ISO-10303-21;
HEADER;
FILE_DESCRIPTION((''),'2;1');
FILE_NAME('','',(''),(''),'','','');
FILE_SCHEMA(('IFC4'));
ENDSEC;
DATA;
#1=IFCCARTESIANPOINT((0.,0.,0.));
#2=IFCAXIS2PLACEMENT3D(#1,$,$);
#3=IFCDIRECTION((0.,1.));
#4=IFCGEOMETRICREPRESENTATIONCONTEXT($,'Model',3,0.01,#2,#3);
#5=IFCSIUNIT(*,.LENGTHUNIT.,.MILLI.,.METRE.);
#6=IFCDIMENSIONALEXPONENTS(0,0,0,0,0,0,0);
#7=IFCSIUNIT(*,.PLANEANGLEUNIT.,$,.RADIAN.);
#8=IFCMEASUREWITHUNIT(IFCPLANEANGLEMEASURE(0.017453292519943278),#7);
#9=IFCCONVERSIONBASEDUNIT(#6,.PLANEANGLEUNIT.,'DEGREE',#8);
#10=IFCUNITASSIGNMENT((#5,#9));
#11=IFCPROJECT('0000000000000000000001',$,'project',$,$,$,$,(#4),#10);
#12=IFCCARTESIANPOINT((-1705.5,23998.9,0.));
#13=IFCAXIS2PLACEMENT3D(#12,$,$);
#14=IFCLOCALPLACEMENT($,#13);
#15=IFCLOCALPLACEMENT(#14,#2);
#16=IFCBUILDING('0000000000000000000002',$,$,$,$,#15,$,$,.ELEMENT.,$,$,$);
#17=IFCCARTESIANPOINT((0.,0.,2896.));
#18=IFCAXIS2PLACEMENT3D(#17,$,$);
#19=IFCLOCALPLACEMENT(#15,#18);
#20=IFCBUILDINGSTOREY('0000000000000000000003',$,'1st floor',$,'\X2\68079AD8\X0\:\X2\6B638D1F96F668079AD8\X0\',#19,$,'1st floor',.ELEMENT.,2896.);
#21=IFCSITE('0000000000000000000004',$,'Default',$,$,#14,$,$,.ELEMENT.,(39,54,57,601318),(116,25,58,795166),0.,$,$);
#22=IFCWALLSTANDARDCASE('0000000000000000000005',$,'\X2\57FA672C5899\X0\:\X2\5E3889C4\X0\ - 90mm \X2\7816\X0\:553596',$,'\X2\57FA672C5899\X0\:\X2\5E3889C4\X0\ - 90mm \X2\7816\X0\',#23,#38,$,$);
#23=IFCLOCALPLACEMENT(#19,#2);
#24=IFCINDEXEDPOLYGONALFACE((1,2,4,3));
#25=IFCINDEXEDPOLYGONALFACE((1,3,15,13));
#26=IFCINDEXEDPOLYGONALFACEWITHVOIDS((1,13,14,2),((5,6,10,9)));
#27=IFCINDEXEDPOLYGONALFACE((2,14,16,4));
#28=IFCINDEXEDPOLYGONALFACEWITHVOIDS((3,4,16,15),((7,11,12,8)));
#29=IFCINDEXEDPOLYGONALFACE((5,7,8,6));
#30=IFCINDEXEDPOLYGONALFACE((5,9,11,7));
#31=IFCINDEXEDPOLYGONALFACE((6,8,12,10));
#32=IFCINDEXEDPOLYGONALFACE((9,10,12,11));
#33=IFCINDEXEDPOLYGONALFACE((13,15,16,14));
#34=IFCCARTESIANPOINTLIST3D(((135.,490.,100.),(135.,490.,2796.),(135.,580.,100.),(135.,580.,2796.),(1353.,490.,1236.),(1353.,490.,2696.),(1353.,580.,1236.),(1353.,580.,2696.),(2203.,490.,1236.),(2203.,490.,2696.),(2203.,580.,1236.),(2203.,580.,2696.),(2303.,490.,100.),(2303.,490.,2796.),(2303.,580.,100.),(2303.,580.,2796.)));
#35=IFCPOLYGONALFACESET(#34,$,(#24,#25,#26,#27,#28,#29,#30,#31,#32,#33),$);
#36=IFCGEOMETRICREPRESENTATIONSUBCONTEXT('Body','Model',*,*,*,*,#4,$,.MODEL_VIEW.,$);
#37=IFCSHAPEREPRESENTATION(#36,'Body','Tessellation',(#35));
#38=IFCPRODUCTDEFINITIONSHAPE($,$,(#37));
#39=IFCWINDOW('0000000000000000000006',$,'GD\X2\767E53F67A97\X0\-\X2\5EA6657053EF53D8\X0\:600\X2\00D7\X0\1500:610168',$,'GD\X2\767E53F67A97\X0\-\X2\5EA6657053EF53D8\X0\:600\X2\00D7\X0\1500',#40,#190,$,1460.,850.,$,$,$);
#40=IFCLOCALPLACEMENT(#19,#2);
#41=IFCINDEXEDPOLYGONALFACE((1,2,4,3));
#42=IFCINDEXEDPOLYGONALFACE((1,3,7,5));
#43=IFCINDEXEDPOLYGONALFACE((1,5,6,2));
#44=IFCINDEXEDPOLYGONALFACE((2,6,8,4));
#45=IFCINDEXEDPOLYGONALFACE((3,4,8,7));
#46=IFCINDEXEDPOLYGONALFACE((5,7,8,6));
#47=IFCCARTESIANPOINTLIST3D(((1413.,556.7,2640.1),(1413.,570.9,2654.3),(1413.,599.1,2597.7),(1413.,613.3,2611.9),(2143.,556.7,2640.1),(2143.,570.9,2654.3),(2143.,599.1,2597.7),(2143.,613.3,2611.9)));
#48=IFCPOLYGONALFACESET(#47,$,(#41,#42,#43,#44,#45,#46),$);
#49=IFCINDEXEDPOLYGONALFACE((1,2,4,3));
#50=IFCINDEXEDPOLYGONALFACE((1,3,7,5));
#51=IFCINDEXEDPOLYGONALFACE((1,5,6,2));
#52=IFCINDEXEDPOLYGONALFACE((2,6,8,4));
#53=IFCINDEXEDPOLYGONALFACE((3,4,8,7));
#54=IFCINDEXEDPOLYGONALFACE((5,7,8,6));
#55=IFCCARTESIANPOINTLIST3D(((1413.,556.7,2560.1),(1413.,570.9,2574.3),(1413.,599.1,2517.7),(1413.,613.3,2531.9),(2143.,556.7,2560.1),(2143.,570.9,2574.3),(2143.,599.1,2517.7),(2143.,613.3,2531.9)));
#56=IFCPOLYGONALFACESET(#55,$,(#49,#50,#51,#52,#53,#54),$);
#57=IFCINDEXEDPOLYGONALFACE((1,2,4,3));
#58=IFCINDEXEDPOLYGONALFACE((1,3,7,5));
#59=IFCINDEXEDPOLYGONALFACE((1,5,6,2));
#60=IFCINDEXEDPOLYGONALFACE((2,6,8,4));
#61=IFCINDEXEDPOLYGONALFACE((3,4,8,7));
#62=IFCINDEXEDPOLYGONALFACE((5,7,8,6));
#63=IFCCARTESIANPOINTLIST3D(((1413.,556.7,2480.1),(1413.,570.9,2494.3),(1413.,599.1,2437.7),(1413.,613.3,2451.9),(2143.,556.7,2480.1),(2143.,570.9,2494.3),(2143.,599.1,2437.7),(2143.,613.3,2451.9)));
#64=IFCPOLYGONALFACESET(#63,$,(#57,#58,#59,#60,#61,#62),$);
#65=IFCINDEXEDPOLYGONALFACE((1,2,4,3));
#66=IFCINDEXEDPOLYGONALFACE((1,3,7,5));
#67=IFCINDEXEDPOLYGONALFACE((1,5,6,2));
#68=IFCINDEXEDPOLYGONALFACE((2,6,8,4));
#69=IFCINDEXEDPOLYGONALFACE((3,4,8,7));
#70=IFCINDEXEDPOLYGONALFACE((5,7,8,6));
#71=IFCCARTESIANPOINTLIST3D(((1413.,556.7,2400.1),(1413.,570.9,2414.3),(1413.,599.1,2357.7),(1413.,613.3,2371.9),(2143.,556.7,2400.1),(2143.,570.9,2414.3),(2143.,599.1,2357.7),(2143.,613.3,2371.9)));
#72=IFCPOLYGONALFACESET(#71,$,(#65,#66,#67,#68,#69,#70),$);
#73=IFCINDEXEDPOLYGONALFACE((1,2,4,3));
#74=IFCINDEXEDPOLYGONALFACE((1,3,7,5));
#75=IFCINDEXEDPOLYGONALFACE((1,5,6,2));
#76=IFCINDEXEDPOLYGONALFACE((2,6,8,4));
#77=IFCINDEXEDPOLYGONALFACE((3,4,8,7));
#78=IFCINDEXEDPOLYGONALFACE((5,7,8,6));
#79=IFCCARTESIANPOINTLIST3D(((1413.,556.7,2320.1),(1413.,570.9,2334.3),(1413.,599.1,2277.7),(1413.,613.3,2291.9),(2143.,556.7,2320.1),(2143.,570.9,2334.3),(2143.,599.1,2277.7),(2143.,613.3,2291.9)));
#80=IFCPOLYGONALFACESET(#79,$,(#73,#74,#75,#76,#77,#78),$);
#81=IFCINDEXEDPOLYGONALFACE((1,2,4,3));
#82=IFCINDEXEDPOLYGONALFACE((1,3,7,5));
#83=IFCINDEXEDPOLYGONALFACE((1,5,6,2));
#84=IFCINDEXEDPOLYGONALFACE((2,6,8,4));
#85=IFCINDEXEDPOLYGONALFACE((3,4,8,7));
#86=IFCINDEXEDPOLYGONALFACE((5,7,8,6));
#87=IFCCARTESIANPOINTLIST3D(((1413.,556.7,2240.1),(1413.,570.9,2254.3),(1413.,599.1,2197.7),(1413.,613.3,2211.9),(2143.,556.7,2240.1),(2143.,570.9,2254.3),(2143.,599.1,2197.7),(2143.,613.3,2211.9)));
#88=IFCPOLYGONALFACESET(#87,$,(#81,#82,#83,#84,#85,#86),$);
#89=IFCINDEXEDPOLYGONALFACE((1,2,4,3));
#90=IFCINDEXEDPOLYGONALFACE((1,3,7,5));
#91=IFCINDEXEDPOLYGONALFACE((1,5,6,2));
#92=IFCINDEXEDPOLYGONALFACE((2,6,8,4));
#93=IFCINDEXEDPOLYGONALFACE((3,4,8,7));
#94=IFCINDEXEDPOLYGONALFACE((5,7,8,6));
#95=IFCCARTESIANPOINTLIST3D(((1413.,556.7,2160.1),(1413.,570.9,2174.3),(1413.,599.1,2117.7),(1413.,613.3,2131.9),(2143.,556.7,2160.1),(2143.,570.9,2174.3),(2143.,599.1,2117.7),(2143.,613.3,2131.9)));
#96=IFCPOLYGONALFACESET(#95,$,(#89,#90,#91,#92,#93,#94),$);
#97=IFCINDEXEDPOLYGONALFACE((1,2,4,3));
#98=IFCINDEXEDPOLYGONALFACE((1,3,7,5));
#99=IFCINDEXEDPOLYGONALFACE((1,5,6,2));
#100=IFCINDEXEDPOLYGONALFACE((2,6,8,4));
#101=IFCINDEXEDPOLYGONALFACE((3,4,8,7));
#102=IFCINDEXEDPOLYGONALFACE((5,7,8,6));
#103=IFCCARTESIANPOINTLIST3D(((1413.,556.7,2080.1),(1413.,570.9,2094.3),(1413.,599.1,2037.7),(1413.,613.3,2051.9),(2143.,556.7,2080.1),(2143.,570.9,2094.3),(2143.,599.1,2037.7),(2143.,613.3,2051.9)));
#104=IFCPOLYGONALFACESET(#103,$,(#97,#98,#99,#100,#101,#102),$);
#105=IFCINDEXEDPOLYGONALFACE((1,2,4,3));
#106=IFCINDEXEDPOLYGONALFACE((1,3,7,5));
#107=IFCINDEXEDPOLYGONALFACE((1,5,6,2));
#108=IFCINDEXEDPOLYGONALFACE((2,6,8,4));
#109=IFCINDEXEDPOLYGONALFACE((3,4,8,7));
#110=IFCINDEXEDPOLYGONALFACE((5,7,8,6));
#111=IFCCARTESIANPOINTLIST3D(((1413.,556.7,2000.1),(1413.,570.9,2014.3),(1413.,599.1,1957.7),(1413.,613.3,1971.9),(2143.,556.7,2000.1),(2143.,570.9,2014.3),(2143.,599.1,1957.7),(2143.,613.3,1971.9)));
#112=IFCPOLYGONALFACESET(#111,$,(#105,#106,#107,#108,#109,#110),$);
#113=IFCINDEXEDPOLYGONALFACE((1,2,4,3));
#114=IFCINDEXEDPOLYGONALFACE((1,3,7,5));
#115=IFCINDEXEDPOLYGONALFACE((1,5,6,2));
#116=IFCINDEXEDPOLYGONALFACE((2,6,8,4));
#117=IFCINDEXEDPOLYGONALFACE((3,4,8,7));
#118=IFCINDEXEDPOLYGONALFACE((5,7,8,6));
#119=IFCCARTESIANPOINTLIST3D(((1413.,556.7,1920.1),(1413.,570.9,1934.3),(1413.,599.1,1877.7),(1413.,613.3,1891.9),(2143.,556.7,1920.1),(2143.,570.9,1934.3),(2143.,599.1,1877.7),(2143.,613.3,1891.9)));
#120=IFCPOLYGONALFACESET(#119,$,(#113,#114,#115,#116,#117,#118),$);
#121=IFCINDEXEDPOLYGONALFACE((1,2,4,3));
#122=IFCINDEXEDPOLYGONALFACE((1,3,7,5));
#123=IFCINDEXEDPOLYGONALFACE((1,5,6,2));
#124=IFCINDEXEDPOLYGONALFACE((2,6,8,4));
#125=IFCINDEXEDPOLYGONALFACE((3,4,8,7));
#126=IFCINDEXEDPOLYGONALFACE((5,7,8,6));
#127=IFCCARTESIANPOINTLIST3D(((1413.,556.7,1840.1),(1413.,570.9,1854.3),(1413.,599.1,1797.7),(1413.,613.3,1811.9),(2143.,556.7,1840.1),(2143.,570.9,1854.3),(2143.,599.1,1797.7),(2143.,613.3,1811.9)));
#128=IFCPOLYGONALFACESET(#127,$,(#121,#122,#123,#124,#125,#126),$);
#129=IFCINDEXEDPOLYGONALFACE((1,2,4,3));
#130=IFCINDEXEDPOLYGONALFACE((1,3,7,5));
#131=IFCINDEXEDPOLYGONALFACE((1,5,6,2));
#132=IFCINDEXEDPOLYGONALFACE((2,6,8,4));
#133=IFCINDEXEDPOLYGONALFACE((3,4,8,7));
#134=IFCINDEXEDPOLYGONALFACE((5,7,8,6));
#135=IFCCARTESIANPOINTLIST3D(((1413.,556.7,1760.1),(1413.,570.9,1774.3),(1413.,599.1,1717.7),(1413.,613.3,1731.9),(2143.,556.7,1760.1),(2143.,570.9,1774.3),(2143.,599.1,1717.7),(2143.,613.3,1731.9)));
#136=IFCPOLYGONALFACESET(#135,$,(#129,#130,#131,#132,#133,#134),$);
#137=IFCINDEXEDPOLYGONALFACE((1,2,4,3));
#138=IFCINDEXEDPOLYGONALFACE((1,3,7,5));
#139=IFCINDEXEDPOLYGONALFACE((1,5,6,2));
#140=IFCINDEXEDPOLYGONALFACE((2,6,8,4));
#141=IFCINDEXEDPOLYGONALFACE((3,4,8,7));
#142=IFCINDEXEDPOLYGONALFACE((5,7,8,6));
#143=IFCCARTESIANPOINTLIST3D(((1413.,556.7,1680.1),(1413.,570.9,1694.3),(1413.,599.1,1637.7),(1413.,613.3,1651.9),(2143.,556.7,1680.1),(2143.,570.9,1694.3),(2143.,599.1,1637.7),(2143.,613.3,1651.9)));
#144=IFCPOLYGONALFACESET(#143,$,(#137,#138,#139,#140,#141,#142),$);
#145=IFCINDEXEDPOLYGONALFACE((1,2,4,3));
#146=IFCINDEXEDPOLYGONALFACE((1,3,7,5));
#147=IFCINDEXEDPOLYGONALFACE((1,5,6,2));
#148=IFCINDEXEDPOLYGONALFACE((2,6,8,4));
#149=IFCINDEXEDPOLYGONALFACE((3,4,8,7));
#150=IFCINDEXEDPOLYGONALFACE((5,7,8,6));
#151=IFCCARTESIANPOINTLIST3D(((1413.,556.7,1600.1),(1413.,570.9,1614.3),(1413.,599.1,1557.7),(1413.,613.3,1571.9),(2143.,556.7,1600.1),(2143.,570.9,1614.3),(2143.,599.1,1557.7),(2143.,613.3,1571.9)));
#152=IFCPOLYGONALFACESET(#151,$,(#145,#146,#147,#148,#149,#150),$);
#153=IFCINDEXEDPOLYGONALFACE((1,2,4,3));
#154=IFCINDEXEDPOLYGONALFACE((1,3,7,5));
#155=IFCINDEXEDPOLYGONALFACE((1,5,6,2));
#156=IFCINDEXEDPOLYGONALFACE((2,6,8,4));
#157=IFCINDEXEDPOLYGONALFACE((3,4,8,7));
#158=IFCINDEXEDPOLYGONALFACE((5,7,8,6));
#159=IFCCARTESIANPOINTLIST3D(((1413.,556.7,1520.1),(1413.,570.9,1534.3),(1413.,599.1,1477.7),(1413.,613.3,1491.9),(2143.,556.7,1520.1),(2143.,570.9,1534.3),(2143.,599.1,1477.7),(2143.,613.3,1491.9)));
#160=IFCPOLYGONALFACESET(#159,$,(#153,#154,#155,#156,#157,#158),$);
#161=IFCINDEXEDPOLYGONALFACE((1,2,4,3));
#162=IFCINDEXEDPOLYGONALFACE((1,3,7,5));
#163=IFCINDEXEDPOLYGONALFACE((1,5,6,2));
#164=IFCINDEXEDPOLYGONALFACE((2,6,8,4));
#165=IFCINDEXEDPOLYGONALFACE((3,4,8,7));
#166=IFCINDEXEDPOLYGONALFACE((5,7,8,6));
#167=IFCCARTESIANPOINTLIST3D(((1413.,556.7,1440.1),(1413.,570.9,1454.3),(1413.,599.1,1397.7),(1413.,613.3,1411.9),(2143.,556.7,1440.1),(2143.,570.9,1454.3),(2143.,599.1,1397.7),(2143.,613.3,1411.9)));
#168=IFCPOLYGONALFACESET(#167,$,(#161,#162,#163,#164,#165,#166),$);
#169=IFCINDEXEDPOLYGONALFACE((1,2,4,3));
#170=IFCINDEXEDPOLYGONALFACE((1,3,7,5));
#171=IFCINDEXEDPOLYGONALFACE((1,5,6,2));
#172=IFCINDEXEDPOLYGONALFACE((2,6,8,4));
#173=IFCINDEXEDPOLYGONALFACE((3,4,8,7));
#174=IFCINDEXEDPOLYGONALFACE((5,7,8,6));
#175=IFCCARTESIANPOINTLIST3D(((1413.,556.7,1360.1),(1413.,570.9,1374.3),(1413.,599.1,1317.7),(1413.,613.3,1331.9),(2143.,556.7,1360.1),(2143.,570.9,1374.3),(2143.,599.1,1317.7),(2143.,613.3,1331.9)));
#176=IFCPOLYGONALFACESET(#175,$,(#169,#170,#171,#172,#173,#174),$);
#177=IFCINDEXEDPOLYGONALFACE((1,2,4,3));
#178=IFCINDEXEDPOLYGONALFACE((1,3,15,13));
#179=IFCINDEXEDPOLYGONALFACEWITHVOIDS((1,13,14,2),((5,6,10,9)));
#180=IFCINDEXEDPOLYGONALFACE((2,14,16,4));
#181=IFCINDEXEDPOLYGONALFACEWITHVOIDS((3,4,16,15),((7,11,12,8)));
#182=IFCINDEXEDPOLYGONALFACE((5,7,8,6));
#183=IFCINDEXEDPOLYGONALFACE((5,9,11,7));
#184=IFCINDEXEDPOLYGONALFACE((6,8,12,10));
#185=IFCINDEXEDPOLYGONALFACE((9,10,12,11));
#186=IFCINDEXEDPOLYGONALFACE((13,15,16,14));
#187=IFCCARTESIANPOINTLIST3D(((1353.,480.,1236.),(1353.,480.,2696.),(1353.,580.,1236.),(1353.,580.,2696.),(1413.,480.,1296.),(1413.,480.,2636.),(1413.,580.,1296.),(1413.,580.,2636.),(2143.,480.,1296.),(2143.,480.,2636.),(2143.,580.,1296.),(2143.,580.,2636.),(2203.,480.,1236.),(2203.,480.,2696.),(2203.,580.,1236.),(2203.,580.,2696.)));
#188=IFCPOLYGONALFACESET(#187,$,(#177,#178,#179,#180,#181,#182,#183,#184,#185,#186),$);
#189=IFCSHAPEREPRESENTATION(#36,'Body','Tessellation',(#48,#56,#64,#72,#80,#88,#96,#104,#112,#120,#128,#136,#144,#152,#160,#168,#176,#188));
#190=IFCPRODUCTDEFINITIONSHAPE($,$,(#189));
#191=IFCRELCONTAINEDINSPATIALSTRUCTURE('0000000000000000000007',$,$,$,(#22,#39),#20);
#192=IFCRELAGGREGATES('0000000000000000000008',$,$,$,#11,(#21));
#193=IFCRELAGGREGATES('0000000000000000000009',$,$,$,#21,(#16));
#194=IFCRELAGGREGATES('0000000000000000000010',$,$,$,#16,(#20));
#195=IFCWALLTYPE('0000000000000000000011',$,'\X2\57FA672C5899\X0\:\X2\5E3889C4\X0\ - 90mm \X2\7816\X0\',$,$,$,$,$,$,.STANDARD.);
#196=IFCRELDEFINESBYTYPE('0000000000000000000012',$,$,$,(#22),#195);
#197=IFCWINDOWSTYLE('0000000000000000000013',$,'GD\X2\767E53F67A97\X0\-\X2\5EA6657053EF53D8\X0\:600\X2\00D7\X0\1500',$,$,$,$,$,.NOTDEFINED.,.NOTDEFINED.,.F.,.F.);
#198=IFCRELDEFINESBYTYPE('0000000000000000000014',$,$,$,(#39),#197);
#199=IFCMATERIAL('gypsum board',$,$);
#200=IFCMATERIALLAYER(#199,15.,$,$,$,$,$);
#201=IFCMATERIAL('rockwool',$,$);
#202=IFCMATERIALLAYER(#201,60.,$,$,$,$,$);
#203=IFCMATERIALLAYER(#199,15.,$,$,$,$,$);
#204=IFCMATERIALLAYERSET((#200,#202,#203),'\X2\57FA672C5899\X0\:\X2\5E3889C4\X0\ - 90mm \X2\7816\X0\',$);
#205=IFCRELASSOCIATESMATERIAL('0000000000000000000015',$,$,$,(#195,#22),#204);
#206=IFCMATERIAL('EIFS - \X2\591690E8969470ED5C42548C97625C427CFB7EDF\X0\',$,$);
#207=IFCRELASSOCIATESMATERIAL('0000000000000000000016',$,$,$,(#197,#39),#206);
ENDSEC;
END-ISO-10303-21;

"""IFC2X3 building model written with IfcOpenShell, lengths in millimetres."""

from ifc_helpers import new_model, entity, si_unit, converted_unit, direction, frame, frame_2d, origin, place, context, subcontext, project, spatial, polyline, rectangle, outline, extrude, source, transform, mapped, material, layer, layer_set, layer_usage, type_object, type_shapes, element, fill, save


model = new_model("IFC2X3")

# Units and contexts
model_context = context("Model", 3, precision=0.01, world=origin(), true_north=direction((0.0, 1.0)))
body_context = subcontext(model_context, "Body", "Model", "MODEL_VIEW")
ifc_project = project(units=[si_unit("LENGTHUNIT", "METRE", prefix="MILLI"), converted_unit("PLANEANGLEUNIT", "DEGREE", entity("IfcPlaneAngleMeasure", 0.017453292519943278), si_unit("PLANEANGLEUNIT", "RADIAN"), dimensions=[0, 0, 0, 0, 0, 0, 0])], contexts=[model_context])

# Site, building, storey
site_placement = place(None, frame((-1705.5, 23998.9, 0.0)))
site = spatial("IfcSite", under=ifc_project, at=site_placement, Name="Default", CompositionType="ELEMENT", RefLatitude=(39, 54, 57, 601318), RefLongitude=(116, 25, 58, 795166), RefElevation=0.0)
building_placement = place(site_placement, origin())
building = spatial("IfcBuilding", under=site, at=building_placement, CompositionType="ELEMENT")
storey_placement = place(building_placement, frame((0.0, 0.0, 2896.0)))
storey = spatial("IfcBuildingStorey", under=building, at=storey_placement, Name="1st floor", ObjectType="标高:正负零标高", LongName="1st floor", CompositionType="ELEMENT", Elevation=2896.0)

# Wall, opening, window
ifc_material_1 = material(Name="gypsum board")
ifc_layer_1 = layer(ifc_material_1, 15.0)
ifc_material_2 = material(Name="rockwool")
ifc_layer_2 = layer(ifc_material_2, 60.0)
ifc_layer_3 = layer(ifc_material_1, 15.0)
ifc_layer_set = layer_set([ifc_layer_1, ifc_layer_2, ifc_layer_3], Name="基本墙:常规 - 90mm 砖")
ifc_layer_usage = layer_usage(ifc_layer_set, "AXIS2", "NEGATIVE", 45.0)
wall_type = type_object("IfcWallType", Name="基本墙:常规 - 90mm 砖", PredefinedType="STANDARD", material=ifc_layer_set)
wall_placement = place(storey_placement, frame((2303.0, 535.0, 100.0), z_axis=(0.0, 0.0, 1.0), x_axis=(-1.0, 0.0, 0.0)))
wall = element("IfcWallStandardCase", 1, at=wall_placement, inside=storey, type_object=wall_type, material=ifc_layer_usage, Name="基本墙:常规 - 90mm 砖:553596", ObjectType="基本墙:常规 - 90mm 砖", context=body_context, shape_type="SweptSolid", body=[
    extrude(rectangle(XDim=2168.0, YDim=90.0, at=frame_2d((1084.0, 0.0), x_axis=(-1.0, 0.0))), origin(), (0.0, 0.0, 1.0), 2696.0),
])
opening_1_placement = place(wall_placement, frame((950.0, 45.0, 1136.0)))
opening_1 = element("IfcOpeningElement", 2, at=opening_1_placement, cuts=wall, ObjectType="Opening", context=body_context, shape_type="SweptSolid", body=[
    extrude(rectangle(XDim=1460.0, YDim=850.0, at=frame_2d((730.0, 425.0), x_axis=(1.0, 0.0))), frame((0.0, 0.0, 0.0), z_axis=(0.0, -1.0, 0.0), x_axis=(0.0, 0.0, 1.0)), (0.0, 0.0, 1.0), 90.0),
])
ifc_material_3 = material(Name="EIFS - 外部隔热层和面层系统")
window_style = type_object("IfcWindowStyle", Name="GD百叶窗-度数可变:600×1500", ConstructionType="NOTDEFINED", OperationType="NOTDEFINED", ParameterTakesPrecedence=False, Sizeable=False, material=ifc_material_3)
shared_shape = source(origin(), body_context, "Body", "SweptSolid", [
    extrude(rectangle(XDim=60.0, YDim=20.0, at=frame_2d((0.0, 0.0), x_axis=(0.0, 1.0))), frame((790.0, 295.0, 1390.0), z_axis=(-1.0, 0.0, 0.0), x_axis=(0.0, -0.707107, -0.707107)), (0.0, 0.0, 1.0), 730.0),
    extrude(rectangle(XDim=60.0, YDim=20.0, at=frame_2d((0.0, 0.0), x_axis=(0.0, 1.0))), frame((790.0, 295.0, 1310.0), z_axis=(-1.0, 0.0, 0.0), x_axis=(0.0, -0.707107, -0.707107)), (0.0, 0.0, 1.0), 730.0),
    extrude(rectangle(XDim=60.0, YDim=20.0, at=frame_2d((0.0, 0.0), x_axis=(0.0, 1.0))), frame((790.0, 295.0, 1230.0), z_axis=(-1.0, 0.0, 0.0), x_axis=(0.0, -0.707107, -0.707107)), (0.0, 0.0, 1.0), 730.0),
    extrude(rectangle(XDim=60.0, YDim=20.0, at=frame_2d((0.0, 0.0), x_axis=(0.0, 1.0))), frame((790.0, 295.0, 1150.0), z_axis=(-1.0, 0.0, 0.0), x_axis=(0.0, -0.707107, -0.707107)), (0.0, 0.0, 1.0), 730.0),
    extrude(rectangle(XDim=60.0, YDim=20.0, at=frame_2d((0.0, 0.0), x_axis=(0.0, 1.0))), frame((790.0, 295.0, 1070.0), z_axis=(-1.0, 0.0, 0.0), x_axis=(0.0, -0.707107, -0.707107)), (0.0, 0.0, 1.0), 730.0),
    extrude(rectangle(XDim=60.0, YDim=20.0, at=frame_2d((0.0, 0.0), x_axis=(0.0, 1.0))), frame((790.0, 295.0, 990.0), z_axis=(-1.0, 0.0, 0.0), x_axis=(0.0, -0.707107, -0.707107)), (0.0, 0.0, 1.0), 730.0),
    extrude(rectangle(XDim=60.0, YDim=20.0, at=frame_2d((0.0, 0.0), x_axis=(0.0, 1.0))), frame((790.0, 295.0, 910.0), z_axis=(-1.0, 0.0, 0.0), x_axis=(0.0, -0.707107, -0.707107)), (0.0, 0.0, 1.0), 730.0),
    extrude(rectangle(XDim=60.0, YDim=20.0, at=frame_2d((0.0, 0.0), x_axis=(0.0, 1.0))), frame((790.0, 295.0, 830.0), z_axis=(-1.0, 0.0, 0.0), x_axis=(0.0, -0.707107, -0.707107)), (0.0, 0.0, 1.0), 730.0),
    extrude(rectangle(XDim=60.0, YDim=20.0, at=frame_2d((0.0, 0.0), x_axis=(0.0, 1.0))), frame((790.0, 295.0, 750.0), z_axis=(-1.0, 0.0, 0.0), x_axis=(0.0, -0.707107, -0.707107)), (0.0, 0.0, 1.0), 730.0),
    extrude(rectangle(XDim=60.0, YDim=20.0, at=frame_2d((0.0, 0.0), x_axis=(0.0, 1.0))), frame((790.0, 295.0, 670.0), z_axis=(-1.0, 0.0, 0.0), x_axis=(0.0, -0.707107, -0.707107)), (0.0, 0.0, 1.0), 730.0),
    extrude(rectangle(XDim=60.0, YDim=20.0, at=frame_2d((0.0, 0.0), x_axis=(0.0, 1.0))), frame((790.0, 295.0, 590.0), z_axis=(-1.0, 0.0, 0.0), x_axis=(0.0, -0.707107, -0.707107)), (0.0, 0.0, 1.0), 730.0),
    extrude(rectangle(XDim=60.0, YDim=20.0, at=frame_2d((0.0, 0.0), x_axis=(0.0, 1.0))), frame((790.0, 295.0, 510.0), z_axis=(-1.0, 0.0, 0.0), x_axis=(0.0, -0.707107, -0.707107)), (0.0, 0.0, 1.0), 730.0),
    extrude(rectangle(XDim=60.0, YDim=20.0, at=frame_2d((0.0, 0.0), x_axis=(0.0, 1.0))), frame((790.0, 295.0, 430.0), z_axis=(-1.0, 0.0, 0.0), x_axis=(0.0, -0.707107, -0.707107)), (0.0, 0.0, 1.0), 730.0),
    extrude(rectangle(XDim=60.0, YDim=20.0, at=frame_2d((0.0, 0.0), x_axis=(0.0, 1.0))), frame((790.0, 295.0, 350.0), z_axis=(-1.0, 0.0, 0.0), x_axis=(0.0, -0.707107, -0.707107)), (0.0, 0.0, 1.0), 730.0),
    extrude(rectangle(XDim=60.0, YDim=20.0, at=frame_2d((0.0, 0.0), x_axis=(0.0, 1.0))), frame((790.0, 295.0, 270.0), z_axis=(-1.0, 0.0, 0.0), x_axis=(0.0, -0.707107, -0.707107)), (0.0, 0.0, 1.0), 730.0),
    extrude(rectangle(XDim=60.0, YDim=20.0, at=frame_2d((0.0, 0.0), x_axis=(0.0, 1.0))), frame((790.0, 295.0, 190.0), z_axis=(-1.0, 0.0, 0.0), x_axis=(0.0, -0.707107, -0.707107)), (0.0, 0.0, 1.0), 730.0),
    extrude(rectangle(XDim=60.0, YDim=20.0, at=frame_2d((0.0, 0.0), x_axis=(0.0, 1.0))), frame((790.0, 295.0, 110.0), z_axis=(-1.0, 0.0, 0.0), x_axis=(0.0, -0.707107, -0.707107)), (0.0, 0.0, 1.0), 730.0),
    extrude(outline(polyline([(-425.0, -730.0), (425.0, -730.0), (425.0, 730.0), (-425.0, 730.0), (-425.0, -730.0)]), holes=[polyline([(365.0, -670.0), (-365.0, -670.0), (-365.0, 670.0), (365.0, 670.0), (365.0, -670.0)])]), frame((425.0, 290.0, 730.0), z_axis=(0.0, -1.0, 0.0), x_axis=(-1.0, 0.0, 0.0)), (0.0, 0.0, 1.0), 100.0),
])
type_shapes(window_style, [shared_shape])
window_placement = place(opening_1_placement, frame((0.0, 200.0, 0.0), z_axis=(0.0, 0.0, 1.0), x_axis=(-1.0, 0.0, 0.0)))
window = element("IfcWindow", 3, at=window_placement, inside=storey, type_object=window_style, material=ifc_material_3, Name="GD百叶窗-度数可变:600×1500:610168", ObjectType="GD百叶窗-度数可变:600×1500", OverallHeight=1460.0, OverallWidth=850.0, context=body_context, shape_type="MappedRepresentation", body=[
    mapped(shared_shape, transform((0.0, 0.0, 0.0), scale=1.0)),
])
fill(opening_1, window)

save(model, "model.ifc")
